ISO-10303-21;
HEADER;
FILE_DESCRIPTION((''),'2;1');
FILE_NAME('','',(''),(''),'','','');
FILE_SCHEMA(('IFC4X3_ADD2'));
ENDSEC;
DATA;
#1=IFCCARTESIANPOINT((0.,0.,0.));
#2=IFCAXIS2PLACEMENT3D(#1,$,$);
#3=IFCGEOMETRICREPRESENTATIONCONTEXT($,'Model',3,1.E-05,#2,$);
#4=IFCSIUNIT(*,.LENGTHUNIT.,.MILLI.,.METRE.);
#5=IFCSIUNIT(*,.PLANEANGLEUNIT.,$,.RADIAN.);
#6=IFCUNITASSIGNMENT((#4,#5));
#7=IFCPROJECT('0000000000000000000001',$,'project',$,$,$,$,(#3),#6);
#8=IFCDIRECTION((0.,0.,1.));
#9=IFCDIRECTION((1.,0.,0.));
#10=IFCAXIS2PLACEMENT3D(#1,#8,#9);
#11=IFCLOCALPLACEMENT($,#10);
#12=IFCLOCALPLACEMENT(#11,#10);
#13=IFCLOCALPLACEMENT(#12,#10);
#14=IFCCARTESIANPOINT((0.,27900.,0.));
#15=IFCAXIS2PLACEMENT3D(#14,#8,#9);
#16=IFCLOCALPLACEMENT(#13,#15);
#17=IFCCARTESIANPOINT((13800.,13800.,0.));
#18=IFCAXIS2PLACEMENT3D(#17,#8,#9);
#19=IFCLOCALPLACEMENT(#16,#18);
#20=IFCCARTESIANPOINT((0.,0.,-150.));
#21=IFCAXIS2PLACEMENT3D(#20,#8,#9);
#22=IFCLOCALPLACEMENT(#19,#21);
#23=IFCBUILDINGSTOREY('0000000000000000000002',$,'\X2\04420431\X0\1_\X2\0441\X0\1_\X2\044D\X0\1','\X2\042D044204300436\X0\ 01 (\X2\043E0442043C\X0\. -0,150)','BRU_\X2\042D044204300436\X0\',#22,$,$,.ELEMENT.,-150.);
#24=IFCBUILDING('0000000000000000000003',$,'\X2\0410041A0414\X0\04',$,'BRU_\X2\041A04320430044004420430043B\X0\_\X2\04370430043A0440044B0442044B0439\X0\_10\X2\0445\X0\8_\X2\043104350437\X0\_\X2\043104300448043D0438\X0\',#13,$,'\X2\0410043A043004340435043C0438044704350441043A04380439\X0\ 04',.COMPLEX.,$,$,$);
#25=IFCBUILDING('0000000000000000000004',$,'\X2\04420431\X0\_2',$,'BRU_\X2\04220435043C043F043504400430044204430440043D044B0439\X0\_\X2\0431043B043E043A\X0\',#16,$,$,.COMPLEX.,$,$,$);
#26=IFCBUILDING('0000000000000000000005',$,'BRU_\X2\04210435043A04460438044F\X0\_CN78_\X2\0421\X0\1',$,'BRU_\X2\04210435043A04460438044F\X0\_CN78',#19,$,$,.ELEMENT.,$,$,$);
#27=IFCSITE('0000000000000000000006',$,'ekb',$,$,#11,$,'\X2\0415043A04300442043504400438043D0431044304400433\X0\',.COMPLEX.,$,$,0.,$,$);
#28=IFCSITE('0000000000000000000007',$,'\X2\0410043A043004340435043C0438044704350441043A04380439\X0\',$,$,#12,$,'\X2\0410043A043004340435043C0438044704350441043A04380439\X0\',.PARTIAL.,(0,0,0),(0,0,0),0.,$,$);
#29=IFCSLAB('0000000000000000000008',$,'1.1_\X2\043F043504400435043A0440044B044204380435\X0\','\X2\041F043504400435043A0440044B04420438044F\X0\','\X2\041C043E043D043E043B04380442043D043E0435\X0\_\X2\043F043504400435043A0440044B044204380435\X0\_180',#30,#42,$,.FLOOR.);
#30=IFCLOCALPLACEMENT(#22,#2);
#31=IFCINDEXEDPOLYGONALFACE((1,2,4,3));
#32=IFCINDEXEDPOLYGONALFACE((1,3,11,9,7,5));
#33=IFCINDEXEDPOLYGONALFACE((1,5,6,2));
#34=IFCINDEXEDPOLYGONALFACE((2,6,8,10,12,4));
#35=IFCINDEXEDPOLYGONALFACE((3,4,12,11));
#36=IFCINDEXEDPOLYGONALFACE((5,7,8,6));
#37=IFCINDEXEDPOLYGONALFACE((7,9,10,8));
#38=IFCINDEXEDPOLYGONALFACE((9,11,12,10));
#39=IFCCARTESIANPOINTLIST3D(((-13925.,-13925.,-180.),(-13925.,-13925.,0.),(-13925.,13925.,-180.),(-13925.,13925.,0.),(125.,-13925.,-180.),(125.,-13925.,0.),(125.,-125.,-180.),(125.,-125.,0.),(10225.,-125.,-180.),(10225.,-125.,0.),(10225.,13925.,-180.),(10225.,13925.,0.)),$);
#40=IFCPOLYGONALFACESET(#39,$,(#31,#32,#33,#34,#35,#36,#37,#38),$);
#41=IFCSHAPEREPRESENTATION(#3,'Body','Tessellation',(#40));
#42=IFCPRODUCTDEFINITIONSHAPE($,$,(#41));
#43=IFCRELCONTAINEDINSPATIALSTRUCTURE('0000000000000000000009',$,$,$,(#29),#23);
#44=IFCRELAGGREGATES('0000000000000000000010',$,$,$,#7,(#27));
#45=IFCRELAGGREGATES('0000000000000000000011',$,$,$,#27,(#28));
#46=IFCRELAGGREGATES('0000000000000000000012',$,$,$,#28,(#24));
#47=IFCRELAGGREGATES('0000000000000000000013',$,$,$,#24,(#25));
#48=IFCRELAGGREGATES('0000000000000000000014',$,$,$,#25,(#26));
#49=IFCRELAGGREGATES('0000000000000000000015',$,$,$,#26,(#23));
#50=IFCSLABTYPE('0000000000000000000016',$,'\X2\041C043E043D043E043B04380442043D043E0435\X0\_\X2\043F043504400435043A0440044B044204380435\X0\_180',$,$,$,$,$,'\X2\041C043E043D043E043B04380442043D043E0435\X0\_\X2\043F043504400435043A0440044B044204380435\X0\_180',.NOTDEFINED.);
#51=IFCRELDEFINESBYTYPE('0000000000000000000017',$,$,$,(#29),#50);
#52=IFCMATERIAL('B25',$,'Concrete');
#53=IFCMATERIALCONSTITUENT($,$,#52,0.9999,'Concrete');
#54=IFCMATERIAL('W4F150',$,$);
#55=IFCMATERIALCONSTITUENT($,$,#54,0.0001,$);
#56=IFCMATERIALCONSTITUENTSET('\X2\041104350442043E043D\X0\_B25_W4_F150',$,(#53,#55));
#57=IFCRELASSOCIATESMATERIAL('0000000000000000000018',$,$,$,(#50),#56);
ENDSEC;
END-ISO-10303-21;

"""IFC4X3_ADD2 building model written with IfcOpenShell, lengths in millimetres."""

from ifc_helpers import new_model, si_unit, frame, origin, origin_with_axes, place, context, project, spatial, polyline, outline, extrude, material, constituent, constituent_set, type_object, element, save


model = new_model("IFC4X3_ADD2")

# Units and contexts
model_context = context("Model", 3, precision=1e-05, world=origin())
ifc_project = project(units=[si_unit("LENGTHUNIT", "METRE", prefix="MILLI"), si_unit("PLANEANGLEUNIT", "RADIAN")], contexts=[model_context])

# Sites, buildings, storey
site_1_placement = place(None, origin_with_axes())
site_1 = spatial("IfcSite", under=ifc_project, at=site_1_placement, Name="ekb", LongName="Екатеринбург", CompositionType="COMPLEX", RefElevation=0.0)
site_2_placement = place(site_1_placement, origin_with_axes())
site_2 = spatial("IfcSite", under=site_1, at=site_2_placement, Name="Академический", LongName="Академический", CompositionType="PARTIAL", RefLatitude=(0, 0, 0), RefLongitude=(0, 0, 0), RefElevation=0.0)
building_1_placement = place(site_2_placement, origin_with_axes())
building_1 = spatial("IfcBuilding", under=site_2, at=building_1_placement, Name="АКД04", ObjectType="BRU_Квартал_закрытый_10х8_без_башни", LongName="Академический 04", CompositionType="COMPLEX")
building_2_placement = place(building_1_placement, frame((0.0, 27900.0, 0.0), z_axis=(0.0, 0.0, 1.0), x_axis=(1.0, 0.0, 0.0)))
building_2 = spatial("IfcBuilding", under=building_1, at=building_2_placement, Name="тб_2", ObjectType="BRU_Температурный_блок", CompositionType="COMPLEX")
building_3_placement = place(building_2_placement, frame((13800.0, 13800.0, 0.0), z_axis=(0.0, 0.0, 1.0), x_axis=(1.0, 0.0, 0.0)))
building_3 = spatial("IfcBuilding", under=building_2, at=building_3_placement, Name="BRU_Секция_CN78_С1", ObjectType="BRU_Секция_CN78", CompositionType="ELEMENT")
storey_placement = place(building_3_placement, frame((0.0, 0.0, -150.0), z_axis=(0.0, 0.0, 1.0), x_axis=(1.0, 0.0, 0.0)))
storey = spatial("IfcBuildingStorey", under=building_3, at=storey_placement, Name="тб1_с1_э1", Description="Этаж 01 (отм. -0,150)", ObjectType="BRU_Этаж", CompositionType="ELEMENT", Elevation=-150.0)

# Shared definitions
ifc_material_1 = material(Name="B25", Category="Concrete")
ifc_material_2 = material(Name="W4F150")

# Slab
ifc_constituent_1 = constituent(ifc_material_1, Category="Concrete", fraction=0.9999)
ifc_constituent_2 = constituent(ifc_material_2, fraction=0.0001)
ifc_constituent_set_1 = constituent_set(constituents=[ifc_constituent_1, ifc_constituent_2], Name="Бетон_B25_W4_F150")
slab_type = type_object("IfcSlabType", Name="Монолитное_перекрытие_180", ElementType="Монолитное_перекрытие_180", PredefinedType="NOTDEFINED", material=ifc_constituent_set_1)
slab_placement = place(storey_placement, frame((0.0, 0.0, -180.0), z_axis=(0.0, 0.0, 1.0), x_axis=(1.0, 0.0, 0.0)))
element("IfcSlab", 1, at=slab_placement, inside=storey, type_object=slab_type, Name="1.1_перекрытие", Description="Перекрытия", ObjectType="Монолитное_перекрытие_180", PredefinedType="FLOOR", context=model_context, shape_type="SweptSolid", body=[
    extrude(outline(polyline([(-13925.0, -13925.0), (125.0, -13925.0), (125.0, -125.0), (10225.0, -125.0), (10225.0, 13925.0), (-13925.0, 13925.0), (-13925.0, -13925.0)])), origin_with_axes(), (0.0, 0.0, 1.0), 180.0),
])

save(model, "model.ifc")
